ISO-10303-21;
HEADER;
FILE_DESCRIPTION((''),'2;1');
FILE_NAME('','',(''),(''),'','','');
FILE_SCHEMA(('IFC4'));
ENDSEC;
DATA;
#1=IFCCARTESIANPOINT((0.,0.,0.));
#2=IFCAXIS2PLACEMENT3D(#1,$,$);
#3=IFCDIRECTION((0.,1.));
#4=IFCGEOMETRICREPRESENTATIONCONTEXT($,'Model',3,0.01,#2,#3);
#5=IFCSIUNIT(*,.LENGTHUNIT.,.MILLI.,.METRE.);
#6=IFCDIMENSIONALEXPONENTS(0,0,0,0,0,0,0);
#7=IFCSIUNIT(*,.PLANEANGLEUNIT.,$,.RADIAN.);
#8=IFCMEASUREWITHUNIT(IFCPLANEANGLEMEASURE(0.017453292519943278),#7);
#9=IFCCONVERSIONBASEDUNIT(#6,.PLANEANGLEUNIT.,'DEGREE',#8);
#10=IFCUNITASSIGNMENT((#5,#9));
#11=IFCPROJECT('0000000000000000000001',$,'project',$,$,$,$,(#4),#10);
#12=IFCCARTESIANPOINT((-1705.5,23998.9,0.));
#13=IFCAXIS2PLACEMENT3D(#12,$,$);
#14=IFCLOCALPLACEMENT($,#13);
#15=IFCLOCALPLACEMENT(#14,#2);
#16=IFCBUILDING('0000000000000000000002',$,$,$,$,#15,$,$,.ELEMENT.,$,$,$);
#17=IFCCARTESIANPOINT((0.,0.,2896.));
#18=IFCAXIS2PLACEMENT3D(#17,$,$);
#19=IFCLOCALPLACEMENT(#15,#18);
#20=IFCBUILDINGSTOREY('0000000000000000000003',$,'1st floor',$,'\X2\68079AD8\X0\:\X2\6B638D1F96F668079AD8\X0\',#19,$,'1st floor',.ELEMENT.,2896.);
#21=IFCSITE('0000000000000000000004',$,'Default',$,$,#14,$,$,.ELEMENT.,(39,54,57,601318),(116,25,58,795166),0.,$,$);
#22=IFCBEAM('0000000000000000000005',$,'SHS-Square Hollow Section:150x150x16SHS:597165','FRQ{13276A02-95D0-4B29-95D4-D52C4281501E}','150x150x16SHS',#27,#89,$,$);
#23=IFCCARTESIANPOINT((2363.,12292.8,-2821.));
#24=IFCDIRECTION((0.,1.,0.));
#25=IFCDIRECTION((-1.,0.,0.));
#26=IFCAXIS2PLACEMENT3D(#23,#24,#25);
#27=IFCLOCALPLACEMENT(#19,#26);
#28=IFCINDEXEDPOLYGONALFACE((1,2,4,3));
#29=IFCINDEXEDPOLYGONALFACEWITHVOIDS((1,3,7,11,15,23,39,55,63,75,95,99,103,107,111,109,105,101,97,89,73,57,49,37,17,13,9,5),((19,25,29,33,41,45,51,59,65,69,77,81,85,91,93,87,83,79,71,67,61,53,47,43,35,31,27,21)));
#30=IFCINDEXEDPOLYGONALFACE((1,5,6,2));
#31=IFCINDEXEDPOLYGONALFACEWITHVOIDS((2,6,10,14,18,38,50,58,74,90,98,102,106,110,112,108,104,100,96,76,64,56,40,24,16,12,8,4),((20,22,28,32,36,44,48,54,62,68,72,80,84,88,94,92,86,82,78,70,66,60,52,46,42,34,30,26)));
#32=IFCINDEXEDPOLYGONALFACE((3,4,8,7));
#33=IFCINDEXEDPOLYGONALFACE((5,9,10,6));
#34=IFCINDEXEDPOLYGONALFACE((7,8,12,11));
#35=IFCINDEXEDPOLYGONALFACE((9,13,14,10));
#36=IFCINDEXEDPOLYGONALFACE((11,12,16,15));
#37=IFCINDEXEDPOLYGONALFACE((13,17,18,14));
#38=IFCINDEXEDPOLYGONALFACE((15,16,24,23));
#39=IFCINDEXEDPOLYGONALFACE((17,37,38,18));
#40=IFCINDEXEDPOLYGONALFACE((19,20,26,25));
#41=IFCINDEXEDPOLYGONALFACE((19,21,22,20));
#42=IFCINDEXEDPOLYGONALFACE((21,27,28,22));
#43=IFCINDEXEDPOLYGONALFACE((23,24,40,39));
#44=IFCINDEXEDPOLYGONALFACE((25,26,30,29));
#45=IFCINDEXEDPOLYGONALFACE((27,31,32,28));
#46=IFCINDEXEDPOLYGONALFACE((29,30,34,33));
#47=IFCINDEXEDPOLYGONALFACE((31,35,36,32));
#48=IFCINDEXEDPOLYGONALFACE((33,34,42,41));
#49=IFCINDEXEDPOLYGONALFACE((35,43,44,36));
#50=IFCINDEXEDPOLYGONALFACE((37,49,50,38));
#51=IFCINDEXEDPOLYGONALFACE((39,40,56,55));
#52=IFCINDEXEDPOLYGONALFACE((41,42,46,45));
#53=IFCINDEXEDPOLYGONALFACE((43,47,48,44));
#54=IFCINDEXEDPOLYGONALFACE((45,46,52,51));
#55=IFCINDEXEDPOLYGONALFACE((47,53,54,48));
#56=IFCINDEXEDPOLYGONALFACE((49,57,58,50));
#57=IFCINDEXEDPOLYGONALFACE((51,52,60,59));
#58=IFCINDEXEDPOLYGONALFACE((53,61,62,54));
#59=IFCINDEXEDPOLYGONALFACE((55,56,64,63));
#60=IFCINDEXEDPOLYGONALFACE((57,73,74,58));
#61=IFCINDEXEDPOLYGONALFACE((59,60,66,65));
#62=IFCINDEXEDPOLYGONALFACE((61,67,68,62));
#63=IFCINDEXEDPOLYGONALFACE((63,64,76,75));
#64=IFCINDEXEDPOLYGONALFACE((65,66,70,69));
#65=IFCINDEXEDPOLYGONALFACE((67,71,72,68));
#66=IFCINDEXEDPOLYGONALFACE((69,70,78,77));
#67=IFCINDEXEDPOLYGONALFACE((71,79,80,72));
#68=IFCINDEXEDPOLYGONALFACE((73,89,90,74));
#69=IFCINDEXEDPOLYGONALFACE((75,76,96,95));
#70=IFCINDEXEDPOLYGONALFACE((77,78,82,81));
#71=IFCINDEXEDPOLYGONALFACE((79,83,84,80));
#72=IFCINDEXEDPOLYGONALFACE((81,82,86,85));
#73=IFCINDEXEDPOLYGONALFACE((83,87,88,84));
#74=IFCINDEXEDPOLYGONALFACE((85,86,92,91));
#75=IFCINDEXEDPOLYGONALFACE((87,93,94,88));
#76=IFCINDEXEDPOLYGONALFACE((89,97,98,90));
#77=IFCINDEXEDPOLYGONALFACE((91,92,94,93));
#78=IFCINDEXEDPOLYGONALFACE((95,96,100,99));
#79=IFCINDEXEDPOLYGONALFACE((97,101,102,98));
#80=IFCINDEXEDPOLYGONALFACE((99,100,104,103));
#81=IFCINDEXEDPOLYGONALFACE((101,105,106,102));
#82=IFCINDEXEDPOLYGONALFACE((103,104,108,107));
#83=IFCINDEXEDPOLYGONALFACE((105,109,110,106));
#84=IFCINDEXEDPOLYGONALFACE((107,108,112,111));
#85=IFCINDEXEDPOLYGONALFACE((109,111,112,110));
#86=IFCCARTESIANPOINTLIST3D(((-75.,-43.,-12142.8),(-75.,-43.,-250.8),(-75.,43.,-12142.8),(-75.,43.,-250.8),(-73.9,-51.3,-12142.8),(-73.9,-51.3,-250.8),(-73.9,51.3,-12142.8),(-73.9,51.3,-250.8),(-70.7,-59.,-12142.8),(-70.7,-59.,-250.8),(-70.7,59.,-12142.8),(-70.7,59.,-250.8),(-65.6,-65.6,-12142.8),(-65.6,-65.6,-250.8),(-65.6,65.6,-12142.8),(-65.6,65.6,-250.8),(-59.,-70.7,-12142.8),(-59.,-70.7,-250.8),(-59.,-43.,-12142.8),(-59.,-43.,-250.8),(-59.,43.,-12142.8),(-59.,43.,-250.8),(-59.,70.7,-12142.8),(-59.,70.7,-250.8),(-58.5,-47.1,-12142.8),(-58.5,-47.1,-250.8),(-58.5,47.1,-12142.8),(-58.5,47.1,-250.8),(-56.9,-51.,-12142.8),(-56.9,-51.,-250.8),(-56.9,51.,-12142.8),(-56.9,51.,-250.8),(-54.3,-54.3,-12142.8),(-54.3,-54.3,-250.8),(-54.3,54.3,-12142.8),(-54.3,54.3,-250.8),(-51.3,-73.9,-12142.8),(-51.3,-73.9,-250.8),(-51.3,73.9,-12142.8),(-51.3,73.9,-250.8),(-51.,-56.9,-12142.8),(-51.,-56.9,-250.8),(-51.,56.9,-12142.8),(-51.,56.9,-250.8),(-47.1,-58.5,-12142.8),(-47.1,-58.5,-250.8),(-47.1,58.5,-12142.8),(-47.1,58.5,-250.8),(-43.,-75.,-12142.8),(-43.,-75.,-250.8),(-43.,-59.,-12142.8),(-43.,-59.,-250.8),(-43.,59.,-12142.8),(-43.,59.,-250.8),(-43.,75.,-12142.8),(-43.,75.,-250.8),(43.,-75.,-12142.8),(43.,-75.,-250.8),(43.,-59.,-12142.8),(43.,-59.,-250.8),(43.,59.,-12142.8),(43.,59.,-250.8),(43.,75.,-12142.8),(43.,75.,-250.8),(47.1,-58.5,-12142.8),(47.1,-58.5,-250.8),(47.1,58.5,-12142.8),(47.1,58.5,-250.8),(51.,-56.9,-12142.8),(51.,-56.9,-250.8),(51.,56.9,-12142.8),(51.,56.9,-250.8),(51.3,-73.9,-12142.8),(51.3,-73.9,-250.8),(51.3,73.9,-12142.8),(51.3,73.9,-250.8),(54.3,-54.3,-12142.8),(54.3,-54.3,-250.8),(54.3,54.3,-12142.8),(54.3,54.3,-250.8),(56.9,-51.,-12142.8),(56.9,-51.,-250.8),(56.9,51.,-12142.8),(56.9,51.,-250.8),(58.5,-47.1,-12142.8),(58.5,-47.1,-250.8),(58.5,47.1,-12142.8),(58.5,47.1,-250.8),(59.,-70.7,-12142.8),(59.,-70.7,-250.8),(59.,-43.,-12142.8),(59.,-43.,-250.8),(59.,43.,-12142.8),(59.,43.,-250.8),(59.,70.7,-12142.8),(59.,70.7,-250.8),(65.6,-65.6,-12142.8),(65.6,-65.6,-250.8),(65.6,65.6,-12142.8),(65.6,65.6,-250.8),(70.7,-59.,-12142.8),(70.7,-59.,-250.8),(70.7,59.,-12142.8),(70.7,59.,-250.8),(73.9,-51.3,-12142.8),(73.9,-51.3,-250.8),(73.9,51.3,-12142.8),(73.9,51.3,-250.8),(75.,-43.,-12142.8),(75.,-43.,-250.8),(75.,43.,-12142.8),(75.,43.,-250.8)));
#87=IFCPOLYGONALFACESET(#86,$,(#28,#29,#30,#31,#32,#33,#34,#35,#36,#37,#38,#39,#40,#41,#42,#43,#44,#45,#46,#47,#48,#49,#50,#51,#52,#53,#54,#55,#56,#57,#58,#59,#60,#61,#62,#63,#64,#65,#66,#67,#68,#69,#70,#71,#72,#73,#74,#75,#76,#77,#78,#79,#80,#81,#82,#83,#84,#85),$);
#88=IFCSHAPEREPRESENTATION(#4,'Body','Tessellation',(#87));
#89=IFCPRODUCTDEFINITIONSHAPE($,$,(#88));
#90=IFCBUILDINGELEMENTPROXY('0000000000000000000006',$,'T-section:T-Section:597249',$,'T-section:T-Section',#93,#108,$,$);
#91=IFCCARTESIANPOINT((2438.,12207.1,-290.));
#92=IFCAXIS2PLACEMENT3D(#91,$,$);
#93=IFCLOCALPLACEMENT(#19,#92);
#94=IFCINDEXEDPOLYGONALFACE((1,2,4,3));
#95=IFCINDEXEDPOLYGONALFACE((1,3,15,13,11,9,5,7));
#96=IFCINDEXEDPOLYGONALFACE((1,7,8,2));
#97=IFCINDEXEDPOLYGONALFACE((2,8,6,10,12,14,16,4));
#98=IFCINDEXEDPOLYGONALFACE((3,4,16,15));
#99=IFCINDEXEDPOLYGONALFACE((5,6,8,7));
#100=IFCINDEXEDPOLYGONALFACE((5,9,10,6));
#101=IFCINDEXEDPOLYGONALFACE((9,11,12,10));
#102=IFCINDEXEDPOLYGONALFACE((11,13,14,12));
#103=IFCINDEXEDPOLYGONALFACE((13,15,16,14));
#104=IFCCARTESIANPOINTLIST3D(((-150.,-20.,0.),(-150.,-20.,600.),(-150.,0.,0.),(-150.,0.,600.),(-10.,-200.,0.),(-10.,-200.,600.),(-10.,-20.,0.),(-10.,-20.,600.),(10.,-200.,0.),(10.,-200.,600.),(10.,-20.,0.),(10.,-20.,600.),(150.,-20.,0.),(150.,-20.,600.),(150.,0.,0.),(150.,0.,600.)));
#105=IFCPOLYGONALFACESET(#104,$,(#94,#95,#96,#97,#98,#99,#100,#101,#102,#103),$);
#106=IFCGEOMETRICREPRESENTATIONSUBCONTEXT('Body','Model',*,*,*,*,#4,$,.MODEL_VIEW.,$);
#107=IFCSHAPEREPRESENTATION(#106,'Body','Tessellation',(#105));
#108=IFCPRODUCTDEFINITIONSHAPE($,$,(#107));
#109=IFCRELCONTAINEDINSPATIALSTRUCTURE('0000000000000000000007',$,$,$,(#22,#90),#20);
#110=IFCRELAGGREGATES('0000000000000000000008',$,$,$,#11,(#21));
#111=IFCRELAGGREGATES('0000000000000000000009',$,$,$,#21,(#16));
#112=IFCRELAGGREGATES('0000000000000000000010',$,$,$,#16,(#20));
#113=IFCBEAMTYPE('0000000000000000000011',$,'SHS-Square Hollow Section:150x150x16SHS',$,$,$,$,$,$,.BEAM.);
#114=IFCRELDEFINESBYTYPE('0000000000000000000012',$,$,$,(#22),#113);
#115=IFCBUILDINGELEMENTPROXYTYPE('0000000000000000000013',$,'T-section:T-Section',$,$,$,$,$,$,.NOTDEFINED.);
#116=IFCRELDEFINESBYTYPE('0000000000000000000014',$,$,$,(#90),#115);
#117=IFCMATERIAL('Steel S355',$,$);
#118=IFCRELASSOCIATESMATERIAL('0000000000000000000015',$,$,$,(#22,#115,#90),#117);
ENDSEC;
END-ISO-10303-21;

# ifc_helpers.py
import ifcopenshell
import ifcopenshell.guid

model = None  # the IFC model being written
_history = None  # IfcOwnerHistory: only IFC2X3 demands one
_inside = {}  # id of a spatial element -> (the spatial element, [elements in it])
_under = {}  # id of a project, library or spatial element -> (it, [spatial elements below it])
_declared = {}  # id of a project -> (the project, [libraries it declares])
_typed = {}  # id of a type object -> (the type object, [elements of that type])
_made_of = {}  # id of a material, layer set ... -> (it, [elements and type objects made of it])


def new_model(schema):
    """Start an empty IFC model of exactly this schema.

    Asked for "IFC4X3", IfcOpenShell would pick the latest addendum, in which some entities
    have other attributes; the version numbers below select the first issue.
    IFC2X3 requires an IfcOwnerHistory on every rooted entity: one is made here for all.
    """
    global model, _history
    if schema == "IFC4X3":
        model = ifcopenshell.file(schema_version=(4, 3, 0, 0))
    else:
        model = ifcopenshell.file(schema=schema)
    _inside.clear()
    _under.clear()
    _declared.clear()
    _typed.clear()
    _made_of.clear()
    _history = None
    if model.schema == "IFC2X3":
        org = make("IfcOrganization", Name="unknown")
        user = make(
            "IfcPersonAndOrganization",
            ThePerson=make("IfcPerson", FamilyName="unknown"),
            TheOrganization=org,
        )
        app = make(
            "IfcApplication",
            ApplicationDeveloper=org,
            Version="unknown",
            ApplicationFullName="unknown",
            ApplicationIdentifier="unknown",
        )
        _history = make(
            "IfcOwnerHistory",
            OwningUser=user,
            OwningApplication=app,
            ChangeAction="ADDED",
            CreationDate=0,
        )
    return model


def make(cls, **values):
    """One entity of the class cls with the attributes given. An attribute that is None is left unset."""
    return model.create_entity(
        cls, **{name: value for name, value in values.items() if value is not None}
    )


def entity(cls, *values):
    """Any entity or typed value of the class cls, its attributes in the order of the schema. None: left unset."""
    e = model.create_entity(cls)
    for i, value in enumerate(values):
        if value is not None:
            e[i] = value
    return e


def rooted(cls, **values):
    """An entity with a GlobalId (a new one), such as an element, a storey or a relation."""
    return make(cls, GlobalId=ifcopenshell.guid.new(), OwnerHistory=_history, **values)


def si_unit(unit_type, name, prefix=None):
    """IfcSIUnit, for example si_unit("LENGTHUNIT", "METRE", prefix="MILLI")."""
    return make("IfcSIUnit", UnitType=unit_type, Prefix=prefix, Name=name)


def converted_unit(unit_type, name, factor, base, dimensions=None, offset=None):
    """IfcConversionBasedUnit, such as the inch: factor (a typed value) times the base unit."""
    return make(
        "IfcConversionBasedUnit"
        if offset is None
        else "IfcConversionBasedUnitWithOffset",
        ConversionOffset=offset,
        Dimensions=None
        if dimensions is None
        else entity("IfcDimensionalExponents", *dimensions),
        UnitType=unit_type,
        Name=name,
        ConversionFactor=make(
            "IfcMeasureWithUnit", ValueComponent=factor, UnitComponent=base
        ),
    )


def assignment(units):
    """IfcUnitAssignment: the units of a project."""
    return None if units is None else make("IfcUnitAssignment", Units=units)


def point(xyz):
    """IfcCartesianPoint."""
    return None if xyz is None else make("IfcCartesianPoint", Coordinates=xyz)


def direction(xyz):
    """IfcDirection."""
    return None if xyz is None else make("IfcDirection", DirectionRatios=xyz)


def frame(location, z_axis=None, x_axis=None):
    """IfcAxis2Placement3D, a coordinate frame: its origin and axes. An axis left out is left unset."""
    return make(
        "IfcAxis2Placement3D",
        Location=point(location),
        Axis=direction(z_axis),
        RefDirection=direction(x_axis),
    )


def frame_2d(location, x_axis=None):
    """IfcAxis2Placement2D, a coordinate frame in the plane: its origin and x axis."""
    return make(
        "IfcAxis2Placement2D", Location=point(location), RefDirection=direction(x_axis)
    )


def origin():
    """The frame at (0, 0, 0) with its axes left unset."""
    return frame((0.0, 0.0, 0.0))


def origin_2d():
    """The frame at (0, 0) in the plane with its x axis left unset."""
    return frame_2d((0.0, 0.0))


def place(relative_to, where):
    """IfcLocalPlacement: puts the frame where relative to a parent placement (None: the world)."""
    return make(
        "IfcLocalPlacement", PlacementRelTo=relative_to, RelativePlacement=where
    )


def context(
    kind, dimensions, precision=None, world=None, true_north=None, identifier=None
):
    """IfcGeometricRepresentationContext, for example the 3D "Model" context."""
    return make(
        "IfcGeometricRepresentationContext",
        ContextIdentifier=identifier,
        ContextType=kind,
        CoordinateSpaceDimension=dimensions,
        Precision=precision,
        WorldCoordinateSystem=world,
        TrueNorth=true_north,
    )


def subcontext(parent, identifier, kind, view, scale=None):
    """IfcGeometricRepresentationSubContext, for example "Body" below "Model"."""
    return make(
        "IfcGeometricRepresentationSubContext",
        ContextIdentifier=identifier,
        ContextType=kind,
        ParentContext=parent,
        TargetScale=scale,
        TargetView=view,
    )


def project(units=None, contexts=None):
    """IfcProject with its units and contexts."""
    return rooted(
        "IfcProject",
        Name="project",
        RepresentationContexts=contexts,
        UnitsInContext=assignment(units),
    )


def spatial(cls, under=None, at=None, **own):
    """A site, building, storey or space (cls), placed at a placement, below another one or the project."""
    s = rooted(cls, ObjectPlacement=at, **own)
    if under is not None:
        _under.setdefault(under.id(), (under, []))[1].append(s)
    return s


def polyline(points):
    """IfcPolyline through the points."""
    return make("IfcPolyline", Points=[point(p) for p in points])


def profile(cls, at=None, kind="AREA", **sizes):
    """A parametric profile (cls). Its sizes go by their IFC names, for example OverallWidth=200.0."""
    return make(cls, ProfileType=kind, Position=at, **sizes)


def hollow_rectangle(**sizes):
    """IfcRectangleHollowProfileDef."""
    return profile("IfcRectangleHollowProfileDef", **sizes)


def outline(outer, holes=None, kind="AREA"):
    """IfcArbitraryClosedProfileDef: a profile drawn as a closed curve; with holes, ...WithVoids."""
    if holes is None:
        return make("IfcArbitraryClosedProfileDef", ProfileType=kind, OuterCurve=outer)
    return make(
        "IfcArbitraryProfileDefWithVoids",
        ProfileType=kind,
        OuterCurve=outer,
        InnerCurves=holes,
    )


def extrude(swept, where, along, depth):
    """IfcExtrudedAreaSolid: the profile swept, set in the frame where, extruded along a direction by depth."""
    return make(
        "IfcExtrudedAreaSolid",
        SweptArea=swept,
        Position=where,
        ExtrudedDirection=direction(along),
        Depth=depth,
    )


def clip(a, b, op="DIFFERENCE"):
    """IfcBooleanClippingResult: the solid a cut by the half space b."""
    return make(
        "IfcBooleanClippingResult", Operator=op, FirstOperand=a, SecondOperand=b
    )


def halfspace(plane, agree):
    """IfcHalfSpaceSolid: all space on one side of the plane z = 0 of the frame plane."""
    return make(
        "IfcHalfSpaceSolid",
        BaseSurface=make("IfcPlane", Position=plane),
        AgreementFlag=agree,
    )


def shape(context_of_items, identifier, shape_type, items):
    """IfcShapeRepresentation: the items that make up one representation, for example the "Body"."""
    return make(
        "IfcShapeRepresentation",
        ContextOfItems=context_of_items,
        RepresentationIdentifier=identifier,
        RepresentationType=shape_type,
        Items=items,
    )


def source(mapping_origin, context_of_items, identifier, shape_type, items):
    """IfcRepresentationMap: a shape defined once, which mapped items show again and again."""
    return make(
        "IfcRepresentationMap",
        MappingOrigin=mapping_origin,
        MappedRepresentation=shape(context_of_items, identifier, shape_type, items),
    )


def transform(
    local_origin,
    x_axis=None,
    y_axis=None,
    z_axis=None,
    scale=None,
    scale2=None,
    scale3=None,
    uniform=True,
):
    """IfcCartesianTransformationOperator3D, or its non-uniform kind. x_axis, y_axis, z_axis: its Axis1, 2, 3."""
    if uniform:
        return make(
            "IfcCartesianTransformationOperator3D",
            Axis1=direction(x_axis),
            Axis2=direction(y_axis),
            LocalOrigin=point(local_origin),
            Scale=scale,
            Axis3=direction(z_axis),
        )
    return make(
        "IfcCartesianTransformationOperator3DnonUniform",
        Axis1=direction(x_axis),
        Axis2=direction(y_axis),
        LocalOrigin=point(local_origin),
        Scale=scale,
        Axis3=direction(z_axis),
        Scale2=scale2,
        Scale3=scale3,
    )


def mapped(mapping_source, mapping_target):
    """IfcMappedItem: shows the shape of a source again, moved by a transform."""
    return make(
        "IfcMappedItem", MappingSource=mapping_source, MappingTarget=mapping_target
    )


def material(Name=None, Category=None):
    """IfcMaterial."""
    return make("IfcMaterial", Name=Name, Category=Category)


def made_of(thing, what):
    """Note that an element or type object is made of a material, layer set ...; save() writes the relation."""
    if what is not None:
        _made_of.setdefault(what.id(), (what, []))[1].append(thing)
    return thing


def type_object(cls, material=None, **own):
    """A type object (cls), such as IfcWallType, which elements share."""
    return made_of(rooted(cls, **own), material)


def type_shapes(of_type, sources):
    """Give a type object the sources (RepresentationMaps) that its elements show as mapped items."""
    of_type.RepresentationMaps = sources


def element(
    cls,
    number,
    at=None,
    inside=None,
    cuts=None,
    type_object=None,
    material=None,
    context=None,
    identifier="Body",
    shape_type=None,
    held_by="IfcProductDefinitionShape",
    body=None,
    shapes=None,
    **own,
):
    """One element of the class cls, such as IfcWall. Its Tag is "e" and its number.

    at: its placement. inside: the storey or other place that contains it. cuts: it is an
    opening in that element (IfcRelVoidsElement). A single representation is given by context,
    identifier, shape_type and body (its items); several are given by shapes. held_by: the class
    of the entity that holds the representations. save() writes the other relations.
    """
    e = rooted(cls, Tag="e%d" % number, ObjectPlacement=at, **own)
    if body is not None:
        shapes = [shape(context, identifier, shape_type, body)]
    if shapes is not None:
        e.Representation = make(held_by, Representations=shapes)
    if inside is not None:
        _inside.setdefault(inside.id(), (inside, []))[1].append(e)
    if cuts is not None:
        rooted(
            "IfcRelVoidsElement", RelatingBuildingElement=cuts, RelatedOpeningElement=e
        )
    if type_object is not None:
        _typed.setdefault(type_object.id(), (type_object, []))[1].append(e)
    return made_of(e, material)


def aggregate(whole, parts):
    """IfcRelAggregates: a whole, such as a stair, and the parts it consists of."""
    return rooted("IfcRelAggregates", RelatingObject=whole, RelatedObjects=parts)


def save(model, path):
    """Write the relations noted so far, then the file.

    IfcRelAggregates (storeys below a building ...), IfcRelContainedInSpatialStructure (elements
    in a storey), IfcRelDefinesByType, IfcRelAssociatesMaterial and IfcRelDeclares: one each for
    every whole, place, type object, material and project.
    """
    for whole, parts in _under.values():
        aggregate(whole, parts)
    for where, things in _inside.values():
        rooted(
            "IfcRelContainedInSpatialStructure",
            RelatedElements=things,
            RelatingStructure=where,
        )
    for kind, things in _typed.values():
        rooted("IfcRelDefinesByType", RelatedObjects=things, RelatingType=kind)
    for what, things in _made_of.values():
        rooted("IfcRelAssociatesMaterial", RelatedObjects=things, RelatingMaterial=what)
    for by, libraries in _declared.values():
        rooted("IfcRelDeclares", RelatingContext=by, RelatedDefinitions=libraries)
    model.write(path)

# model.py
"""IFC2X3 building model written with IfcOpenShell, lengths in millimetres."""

from ifc_helpers import new_model, entity, si_unit, converted_unit, direction, frame, origin, origin_2d, place, context, subcontext, project, spatial, polyline, hollow_rectangle, outline, extrude, clip, halfspace, source, transform, mapped, material, type_object, type_shapes, element, save


model = new_model("IFC2X3")

# Units and contexts
model_context = context("Model", 3, precision=0.01, world=origin(), true_north=direction((0.0, 1.0)))
body_context = subcontext(model_context, "Body", "Model", "MODEL_VIEW")
ifc_project = project(units=[si_unit("LENGTHUNIT", "METRE", prefix="MILLI"), converted_unit("PLANEANGLEUNIT", "DEGREE", entity("IfcPlaneAngleMeasure", 0.017453292519943278), si_unit("PLANEANGLEUNIT", "RADIAN"), dimensions=[0, 0, 0, 0, 0, 0, 0])], contexts=[model_context])

# Site, building, storey
site_placement = place(None, frame((-1705.5, 23998.9, 0.0)))
site = spatial("IfcSite", under=ifc_project, at=site_placement, Name="Default", CompositionType="ELEMENT", RefLatitude=(39, 54, 57, 601318), RefLongitude=(116, 25, 58, 795166), RefElevation=0.0)
building_placement = place(site_placement, origin())
building = spatial("IfcBuilding", under=site, at=building_placement, CompositionType="ELEMENT")
storey_placement = place(building_placement, frame((0.0, 0.0, 2896.0)))
storey = spatial("IfcBuildingStorey", under=building, at=storey_placement, Name="1st floor", ObjectType="标高:正负零标高", LongName="1st floor", CompositionType="ELEMENT", Elevation=2896.0)

# Shared definitions
ifc_material_1 = material(Name="Steel S355")

# Shared definitions
beam_type_1 = type_object("IfcBeamType", Name="SHS-Square Hollow Section:150x150x16SHS", PredefinedType="BEAM")

# Beam
beam_1_placement = place(storey_placement, frame((2363.0, 12292.8, -2821.0), z_axis=(0.0, 1.0, 0.0), x_axis=(-1.0, 0.0, 0.0)))
element("IfcBeam", 1, at=beam_1_placement, inside=storey, type_object=beam_type_1, material=ifc_material_1, Name="SHS-Square Hollow Section:150x150x16SHS:597165", Description="FRQ{13276A02-95D0-4B29-95D4-D52C4281501E}", ObjectType="150x150x16SHS", context=model_context, shape_type="Clipping", body=[
    clip(clip(extrude(hollow_rectangle(XDim=150.0, YDim=150.0, WallThickness=16.0, InnerFilletRadius=16.0, OuterFilletRadius=32.0, at=origin_2d()), origin(), (0.0, 0.0, -1.0), 12398.9), halfspace(frame((2363.0, -75.0, -12142.8), z_axis=(0.0, 0.0, 1.0), x_axis=(1.0, 0.0, 0.0)), True)), halfspace(frame((2363.0, -75.0, -250.8), z_axis=(0.0, 0.0, -1.0), x_axis=(-1.0, 0.0, 0.0)), True)),
])

# Building element proxy
building_element_proxy_type_1 = type_object("IfcBuildingElementProxyType", Name="T-section:T-Section", PredefinedType="NOTDEFINED", material=ifc_material_1)
shared_shape_1 = source(origin(), body_context, "Body", "SweptSolid", [
    extrude(outline(polyline([(-10.0, -140.0), (10.0, -140.0), (10.0, 40.0), (150.0, 40.0), (150.0, 60.0), (-150.0, 60.0), (-150.0, 40.0), (-10.0, 40.0), (-10.0, -140.0)])), frame((0.0, -60.0, 0.0)), (0.0, 0.0, 1.0), 600.0),
])
type_shapes(building_element_proxy_type_1, [shared_shape_1])
proxy_placement = place(storey_placement, frame((2438.0, 12207.1, -290.0)))
element("IfcBuildingElementProxy", 2, at=proxy_placement, inside=storey, type_object=building_element_proxy_type_1, material=ifc_material_1, Name="T-section:T-Section:597249", ObjectType="T-section:T-Section", context=body_context, shape_type="MappedRepresentation", body=[
    mapped(shared_shape_1, transform((0.0, 0.0, 0.0), scale=1.0)),
])

save(model, "model.ifc")
